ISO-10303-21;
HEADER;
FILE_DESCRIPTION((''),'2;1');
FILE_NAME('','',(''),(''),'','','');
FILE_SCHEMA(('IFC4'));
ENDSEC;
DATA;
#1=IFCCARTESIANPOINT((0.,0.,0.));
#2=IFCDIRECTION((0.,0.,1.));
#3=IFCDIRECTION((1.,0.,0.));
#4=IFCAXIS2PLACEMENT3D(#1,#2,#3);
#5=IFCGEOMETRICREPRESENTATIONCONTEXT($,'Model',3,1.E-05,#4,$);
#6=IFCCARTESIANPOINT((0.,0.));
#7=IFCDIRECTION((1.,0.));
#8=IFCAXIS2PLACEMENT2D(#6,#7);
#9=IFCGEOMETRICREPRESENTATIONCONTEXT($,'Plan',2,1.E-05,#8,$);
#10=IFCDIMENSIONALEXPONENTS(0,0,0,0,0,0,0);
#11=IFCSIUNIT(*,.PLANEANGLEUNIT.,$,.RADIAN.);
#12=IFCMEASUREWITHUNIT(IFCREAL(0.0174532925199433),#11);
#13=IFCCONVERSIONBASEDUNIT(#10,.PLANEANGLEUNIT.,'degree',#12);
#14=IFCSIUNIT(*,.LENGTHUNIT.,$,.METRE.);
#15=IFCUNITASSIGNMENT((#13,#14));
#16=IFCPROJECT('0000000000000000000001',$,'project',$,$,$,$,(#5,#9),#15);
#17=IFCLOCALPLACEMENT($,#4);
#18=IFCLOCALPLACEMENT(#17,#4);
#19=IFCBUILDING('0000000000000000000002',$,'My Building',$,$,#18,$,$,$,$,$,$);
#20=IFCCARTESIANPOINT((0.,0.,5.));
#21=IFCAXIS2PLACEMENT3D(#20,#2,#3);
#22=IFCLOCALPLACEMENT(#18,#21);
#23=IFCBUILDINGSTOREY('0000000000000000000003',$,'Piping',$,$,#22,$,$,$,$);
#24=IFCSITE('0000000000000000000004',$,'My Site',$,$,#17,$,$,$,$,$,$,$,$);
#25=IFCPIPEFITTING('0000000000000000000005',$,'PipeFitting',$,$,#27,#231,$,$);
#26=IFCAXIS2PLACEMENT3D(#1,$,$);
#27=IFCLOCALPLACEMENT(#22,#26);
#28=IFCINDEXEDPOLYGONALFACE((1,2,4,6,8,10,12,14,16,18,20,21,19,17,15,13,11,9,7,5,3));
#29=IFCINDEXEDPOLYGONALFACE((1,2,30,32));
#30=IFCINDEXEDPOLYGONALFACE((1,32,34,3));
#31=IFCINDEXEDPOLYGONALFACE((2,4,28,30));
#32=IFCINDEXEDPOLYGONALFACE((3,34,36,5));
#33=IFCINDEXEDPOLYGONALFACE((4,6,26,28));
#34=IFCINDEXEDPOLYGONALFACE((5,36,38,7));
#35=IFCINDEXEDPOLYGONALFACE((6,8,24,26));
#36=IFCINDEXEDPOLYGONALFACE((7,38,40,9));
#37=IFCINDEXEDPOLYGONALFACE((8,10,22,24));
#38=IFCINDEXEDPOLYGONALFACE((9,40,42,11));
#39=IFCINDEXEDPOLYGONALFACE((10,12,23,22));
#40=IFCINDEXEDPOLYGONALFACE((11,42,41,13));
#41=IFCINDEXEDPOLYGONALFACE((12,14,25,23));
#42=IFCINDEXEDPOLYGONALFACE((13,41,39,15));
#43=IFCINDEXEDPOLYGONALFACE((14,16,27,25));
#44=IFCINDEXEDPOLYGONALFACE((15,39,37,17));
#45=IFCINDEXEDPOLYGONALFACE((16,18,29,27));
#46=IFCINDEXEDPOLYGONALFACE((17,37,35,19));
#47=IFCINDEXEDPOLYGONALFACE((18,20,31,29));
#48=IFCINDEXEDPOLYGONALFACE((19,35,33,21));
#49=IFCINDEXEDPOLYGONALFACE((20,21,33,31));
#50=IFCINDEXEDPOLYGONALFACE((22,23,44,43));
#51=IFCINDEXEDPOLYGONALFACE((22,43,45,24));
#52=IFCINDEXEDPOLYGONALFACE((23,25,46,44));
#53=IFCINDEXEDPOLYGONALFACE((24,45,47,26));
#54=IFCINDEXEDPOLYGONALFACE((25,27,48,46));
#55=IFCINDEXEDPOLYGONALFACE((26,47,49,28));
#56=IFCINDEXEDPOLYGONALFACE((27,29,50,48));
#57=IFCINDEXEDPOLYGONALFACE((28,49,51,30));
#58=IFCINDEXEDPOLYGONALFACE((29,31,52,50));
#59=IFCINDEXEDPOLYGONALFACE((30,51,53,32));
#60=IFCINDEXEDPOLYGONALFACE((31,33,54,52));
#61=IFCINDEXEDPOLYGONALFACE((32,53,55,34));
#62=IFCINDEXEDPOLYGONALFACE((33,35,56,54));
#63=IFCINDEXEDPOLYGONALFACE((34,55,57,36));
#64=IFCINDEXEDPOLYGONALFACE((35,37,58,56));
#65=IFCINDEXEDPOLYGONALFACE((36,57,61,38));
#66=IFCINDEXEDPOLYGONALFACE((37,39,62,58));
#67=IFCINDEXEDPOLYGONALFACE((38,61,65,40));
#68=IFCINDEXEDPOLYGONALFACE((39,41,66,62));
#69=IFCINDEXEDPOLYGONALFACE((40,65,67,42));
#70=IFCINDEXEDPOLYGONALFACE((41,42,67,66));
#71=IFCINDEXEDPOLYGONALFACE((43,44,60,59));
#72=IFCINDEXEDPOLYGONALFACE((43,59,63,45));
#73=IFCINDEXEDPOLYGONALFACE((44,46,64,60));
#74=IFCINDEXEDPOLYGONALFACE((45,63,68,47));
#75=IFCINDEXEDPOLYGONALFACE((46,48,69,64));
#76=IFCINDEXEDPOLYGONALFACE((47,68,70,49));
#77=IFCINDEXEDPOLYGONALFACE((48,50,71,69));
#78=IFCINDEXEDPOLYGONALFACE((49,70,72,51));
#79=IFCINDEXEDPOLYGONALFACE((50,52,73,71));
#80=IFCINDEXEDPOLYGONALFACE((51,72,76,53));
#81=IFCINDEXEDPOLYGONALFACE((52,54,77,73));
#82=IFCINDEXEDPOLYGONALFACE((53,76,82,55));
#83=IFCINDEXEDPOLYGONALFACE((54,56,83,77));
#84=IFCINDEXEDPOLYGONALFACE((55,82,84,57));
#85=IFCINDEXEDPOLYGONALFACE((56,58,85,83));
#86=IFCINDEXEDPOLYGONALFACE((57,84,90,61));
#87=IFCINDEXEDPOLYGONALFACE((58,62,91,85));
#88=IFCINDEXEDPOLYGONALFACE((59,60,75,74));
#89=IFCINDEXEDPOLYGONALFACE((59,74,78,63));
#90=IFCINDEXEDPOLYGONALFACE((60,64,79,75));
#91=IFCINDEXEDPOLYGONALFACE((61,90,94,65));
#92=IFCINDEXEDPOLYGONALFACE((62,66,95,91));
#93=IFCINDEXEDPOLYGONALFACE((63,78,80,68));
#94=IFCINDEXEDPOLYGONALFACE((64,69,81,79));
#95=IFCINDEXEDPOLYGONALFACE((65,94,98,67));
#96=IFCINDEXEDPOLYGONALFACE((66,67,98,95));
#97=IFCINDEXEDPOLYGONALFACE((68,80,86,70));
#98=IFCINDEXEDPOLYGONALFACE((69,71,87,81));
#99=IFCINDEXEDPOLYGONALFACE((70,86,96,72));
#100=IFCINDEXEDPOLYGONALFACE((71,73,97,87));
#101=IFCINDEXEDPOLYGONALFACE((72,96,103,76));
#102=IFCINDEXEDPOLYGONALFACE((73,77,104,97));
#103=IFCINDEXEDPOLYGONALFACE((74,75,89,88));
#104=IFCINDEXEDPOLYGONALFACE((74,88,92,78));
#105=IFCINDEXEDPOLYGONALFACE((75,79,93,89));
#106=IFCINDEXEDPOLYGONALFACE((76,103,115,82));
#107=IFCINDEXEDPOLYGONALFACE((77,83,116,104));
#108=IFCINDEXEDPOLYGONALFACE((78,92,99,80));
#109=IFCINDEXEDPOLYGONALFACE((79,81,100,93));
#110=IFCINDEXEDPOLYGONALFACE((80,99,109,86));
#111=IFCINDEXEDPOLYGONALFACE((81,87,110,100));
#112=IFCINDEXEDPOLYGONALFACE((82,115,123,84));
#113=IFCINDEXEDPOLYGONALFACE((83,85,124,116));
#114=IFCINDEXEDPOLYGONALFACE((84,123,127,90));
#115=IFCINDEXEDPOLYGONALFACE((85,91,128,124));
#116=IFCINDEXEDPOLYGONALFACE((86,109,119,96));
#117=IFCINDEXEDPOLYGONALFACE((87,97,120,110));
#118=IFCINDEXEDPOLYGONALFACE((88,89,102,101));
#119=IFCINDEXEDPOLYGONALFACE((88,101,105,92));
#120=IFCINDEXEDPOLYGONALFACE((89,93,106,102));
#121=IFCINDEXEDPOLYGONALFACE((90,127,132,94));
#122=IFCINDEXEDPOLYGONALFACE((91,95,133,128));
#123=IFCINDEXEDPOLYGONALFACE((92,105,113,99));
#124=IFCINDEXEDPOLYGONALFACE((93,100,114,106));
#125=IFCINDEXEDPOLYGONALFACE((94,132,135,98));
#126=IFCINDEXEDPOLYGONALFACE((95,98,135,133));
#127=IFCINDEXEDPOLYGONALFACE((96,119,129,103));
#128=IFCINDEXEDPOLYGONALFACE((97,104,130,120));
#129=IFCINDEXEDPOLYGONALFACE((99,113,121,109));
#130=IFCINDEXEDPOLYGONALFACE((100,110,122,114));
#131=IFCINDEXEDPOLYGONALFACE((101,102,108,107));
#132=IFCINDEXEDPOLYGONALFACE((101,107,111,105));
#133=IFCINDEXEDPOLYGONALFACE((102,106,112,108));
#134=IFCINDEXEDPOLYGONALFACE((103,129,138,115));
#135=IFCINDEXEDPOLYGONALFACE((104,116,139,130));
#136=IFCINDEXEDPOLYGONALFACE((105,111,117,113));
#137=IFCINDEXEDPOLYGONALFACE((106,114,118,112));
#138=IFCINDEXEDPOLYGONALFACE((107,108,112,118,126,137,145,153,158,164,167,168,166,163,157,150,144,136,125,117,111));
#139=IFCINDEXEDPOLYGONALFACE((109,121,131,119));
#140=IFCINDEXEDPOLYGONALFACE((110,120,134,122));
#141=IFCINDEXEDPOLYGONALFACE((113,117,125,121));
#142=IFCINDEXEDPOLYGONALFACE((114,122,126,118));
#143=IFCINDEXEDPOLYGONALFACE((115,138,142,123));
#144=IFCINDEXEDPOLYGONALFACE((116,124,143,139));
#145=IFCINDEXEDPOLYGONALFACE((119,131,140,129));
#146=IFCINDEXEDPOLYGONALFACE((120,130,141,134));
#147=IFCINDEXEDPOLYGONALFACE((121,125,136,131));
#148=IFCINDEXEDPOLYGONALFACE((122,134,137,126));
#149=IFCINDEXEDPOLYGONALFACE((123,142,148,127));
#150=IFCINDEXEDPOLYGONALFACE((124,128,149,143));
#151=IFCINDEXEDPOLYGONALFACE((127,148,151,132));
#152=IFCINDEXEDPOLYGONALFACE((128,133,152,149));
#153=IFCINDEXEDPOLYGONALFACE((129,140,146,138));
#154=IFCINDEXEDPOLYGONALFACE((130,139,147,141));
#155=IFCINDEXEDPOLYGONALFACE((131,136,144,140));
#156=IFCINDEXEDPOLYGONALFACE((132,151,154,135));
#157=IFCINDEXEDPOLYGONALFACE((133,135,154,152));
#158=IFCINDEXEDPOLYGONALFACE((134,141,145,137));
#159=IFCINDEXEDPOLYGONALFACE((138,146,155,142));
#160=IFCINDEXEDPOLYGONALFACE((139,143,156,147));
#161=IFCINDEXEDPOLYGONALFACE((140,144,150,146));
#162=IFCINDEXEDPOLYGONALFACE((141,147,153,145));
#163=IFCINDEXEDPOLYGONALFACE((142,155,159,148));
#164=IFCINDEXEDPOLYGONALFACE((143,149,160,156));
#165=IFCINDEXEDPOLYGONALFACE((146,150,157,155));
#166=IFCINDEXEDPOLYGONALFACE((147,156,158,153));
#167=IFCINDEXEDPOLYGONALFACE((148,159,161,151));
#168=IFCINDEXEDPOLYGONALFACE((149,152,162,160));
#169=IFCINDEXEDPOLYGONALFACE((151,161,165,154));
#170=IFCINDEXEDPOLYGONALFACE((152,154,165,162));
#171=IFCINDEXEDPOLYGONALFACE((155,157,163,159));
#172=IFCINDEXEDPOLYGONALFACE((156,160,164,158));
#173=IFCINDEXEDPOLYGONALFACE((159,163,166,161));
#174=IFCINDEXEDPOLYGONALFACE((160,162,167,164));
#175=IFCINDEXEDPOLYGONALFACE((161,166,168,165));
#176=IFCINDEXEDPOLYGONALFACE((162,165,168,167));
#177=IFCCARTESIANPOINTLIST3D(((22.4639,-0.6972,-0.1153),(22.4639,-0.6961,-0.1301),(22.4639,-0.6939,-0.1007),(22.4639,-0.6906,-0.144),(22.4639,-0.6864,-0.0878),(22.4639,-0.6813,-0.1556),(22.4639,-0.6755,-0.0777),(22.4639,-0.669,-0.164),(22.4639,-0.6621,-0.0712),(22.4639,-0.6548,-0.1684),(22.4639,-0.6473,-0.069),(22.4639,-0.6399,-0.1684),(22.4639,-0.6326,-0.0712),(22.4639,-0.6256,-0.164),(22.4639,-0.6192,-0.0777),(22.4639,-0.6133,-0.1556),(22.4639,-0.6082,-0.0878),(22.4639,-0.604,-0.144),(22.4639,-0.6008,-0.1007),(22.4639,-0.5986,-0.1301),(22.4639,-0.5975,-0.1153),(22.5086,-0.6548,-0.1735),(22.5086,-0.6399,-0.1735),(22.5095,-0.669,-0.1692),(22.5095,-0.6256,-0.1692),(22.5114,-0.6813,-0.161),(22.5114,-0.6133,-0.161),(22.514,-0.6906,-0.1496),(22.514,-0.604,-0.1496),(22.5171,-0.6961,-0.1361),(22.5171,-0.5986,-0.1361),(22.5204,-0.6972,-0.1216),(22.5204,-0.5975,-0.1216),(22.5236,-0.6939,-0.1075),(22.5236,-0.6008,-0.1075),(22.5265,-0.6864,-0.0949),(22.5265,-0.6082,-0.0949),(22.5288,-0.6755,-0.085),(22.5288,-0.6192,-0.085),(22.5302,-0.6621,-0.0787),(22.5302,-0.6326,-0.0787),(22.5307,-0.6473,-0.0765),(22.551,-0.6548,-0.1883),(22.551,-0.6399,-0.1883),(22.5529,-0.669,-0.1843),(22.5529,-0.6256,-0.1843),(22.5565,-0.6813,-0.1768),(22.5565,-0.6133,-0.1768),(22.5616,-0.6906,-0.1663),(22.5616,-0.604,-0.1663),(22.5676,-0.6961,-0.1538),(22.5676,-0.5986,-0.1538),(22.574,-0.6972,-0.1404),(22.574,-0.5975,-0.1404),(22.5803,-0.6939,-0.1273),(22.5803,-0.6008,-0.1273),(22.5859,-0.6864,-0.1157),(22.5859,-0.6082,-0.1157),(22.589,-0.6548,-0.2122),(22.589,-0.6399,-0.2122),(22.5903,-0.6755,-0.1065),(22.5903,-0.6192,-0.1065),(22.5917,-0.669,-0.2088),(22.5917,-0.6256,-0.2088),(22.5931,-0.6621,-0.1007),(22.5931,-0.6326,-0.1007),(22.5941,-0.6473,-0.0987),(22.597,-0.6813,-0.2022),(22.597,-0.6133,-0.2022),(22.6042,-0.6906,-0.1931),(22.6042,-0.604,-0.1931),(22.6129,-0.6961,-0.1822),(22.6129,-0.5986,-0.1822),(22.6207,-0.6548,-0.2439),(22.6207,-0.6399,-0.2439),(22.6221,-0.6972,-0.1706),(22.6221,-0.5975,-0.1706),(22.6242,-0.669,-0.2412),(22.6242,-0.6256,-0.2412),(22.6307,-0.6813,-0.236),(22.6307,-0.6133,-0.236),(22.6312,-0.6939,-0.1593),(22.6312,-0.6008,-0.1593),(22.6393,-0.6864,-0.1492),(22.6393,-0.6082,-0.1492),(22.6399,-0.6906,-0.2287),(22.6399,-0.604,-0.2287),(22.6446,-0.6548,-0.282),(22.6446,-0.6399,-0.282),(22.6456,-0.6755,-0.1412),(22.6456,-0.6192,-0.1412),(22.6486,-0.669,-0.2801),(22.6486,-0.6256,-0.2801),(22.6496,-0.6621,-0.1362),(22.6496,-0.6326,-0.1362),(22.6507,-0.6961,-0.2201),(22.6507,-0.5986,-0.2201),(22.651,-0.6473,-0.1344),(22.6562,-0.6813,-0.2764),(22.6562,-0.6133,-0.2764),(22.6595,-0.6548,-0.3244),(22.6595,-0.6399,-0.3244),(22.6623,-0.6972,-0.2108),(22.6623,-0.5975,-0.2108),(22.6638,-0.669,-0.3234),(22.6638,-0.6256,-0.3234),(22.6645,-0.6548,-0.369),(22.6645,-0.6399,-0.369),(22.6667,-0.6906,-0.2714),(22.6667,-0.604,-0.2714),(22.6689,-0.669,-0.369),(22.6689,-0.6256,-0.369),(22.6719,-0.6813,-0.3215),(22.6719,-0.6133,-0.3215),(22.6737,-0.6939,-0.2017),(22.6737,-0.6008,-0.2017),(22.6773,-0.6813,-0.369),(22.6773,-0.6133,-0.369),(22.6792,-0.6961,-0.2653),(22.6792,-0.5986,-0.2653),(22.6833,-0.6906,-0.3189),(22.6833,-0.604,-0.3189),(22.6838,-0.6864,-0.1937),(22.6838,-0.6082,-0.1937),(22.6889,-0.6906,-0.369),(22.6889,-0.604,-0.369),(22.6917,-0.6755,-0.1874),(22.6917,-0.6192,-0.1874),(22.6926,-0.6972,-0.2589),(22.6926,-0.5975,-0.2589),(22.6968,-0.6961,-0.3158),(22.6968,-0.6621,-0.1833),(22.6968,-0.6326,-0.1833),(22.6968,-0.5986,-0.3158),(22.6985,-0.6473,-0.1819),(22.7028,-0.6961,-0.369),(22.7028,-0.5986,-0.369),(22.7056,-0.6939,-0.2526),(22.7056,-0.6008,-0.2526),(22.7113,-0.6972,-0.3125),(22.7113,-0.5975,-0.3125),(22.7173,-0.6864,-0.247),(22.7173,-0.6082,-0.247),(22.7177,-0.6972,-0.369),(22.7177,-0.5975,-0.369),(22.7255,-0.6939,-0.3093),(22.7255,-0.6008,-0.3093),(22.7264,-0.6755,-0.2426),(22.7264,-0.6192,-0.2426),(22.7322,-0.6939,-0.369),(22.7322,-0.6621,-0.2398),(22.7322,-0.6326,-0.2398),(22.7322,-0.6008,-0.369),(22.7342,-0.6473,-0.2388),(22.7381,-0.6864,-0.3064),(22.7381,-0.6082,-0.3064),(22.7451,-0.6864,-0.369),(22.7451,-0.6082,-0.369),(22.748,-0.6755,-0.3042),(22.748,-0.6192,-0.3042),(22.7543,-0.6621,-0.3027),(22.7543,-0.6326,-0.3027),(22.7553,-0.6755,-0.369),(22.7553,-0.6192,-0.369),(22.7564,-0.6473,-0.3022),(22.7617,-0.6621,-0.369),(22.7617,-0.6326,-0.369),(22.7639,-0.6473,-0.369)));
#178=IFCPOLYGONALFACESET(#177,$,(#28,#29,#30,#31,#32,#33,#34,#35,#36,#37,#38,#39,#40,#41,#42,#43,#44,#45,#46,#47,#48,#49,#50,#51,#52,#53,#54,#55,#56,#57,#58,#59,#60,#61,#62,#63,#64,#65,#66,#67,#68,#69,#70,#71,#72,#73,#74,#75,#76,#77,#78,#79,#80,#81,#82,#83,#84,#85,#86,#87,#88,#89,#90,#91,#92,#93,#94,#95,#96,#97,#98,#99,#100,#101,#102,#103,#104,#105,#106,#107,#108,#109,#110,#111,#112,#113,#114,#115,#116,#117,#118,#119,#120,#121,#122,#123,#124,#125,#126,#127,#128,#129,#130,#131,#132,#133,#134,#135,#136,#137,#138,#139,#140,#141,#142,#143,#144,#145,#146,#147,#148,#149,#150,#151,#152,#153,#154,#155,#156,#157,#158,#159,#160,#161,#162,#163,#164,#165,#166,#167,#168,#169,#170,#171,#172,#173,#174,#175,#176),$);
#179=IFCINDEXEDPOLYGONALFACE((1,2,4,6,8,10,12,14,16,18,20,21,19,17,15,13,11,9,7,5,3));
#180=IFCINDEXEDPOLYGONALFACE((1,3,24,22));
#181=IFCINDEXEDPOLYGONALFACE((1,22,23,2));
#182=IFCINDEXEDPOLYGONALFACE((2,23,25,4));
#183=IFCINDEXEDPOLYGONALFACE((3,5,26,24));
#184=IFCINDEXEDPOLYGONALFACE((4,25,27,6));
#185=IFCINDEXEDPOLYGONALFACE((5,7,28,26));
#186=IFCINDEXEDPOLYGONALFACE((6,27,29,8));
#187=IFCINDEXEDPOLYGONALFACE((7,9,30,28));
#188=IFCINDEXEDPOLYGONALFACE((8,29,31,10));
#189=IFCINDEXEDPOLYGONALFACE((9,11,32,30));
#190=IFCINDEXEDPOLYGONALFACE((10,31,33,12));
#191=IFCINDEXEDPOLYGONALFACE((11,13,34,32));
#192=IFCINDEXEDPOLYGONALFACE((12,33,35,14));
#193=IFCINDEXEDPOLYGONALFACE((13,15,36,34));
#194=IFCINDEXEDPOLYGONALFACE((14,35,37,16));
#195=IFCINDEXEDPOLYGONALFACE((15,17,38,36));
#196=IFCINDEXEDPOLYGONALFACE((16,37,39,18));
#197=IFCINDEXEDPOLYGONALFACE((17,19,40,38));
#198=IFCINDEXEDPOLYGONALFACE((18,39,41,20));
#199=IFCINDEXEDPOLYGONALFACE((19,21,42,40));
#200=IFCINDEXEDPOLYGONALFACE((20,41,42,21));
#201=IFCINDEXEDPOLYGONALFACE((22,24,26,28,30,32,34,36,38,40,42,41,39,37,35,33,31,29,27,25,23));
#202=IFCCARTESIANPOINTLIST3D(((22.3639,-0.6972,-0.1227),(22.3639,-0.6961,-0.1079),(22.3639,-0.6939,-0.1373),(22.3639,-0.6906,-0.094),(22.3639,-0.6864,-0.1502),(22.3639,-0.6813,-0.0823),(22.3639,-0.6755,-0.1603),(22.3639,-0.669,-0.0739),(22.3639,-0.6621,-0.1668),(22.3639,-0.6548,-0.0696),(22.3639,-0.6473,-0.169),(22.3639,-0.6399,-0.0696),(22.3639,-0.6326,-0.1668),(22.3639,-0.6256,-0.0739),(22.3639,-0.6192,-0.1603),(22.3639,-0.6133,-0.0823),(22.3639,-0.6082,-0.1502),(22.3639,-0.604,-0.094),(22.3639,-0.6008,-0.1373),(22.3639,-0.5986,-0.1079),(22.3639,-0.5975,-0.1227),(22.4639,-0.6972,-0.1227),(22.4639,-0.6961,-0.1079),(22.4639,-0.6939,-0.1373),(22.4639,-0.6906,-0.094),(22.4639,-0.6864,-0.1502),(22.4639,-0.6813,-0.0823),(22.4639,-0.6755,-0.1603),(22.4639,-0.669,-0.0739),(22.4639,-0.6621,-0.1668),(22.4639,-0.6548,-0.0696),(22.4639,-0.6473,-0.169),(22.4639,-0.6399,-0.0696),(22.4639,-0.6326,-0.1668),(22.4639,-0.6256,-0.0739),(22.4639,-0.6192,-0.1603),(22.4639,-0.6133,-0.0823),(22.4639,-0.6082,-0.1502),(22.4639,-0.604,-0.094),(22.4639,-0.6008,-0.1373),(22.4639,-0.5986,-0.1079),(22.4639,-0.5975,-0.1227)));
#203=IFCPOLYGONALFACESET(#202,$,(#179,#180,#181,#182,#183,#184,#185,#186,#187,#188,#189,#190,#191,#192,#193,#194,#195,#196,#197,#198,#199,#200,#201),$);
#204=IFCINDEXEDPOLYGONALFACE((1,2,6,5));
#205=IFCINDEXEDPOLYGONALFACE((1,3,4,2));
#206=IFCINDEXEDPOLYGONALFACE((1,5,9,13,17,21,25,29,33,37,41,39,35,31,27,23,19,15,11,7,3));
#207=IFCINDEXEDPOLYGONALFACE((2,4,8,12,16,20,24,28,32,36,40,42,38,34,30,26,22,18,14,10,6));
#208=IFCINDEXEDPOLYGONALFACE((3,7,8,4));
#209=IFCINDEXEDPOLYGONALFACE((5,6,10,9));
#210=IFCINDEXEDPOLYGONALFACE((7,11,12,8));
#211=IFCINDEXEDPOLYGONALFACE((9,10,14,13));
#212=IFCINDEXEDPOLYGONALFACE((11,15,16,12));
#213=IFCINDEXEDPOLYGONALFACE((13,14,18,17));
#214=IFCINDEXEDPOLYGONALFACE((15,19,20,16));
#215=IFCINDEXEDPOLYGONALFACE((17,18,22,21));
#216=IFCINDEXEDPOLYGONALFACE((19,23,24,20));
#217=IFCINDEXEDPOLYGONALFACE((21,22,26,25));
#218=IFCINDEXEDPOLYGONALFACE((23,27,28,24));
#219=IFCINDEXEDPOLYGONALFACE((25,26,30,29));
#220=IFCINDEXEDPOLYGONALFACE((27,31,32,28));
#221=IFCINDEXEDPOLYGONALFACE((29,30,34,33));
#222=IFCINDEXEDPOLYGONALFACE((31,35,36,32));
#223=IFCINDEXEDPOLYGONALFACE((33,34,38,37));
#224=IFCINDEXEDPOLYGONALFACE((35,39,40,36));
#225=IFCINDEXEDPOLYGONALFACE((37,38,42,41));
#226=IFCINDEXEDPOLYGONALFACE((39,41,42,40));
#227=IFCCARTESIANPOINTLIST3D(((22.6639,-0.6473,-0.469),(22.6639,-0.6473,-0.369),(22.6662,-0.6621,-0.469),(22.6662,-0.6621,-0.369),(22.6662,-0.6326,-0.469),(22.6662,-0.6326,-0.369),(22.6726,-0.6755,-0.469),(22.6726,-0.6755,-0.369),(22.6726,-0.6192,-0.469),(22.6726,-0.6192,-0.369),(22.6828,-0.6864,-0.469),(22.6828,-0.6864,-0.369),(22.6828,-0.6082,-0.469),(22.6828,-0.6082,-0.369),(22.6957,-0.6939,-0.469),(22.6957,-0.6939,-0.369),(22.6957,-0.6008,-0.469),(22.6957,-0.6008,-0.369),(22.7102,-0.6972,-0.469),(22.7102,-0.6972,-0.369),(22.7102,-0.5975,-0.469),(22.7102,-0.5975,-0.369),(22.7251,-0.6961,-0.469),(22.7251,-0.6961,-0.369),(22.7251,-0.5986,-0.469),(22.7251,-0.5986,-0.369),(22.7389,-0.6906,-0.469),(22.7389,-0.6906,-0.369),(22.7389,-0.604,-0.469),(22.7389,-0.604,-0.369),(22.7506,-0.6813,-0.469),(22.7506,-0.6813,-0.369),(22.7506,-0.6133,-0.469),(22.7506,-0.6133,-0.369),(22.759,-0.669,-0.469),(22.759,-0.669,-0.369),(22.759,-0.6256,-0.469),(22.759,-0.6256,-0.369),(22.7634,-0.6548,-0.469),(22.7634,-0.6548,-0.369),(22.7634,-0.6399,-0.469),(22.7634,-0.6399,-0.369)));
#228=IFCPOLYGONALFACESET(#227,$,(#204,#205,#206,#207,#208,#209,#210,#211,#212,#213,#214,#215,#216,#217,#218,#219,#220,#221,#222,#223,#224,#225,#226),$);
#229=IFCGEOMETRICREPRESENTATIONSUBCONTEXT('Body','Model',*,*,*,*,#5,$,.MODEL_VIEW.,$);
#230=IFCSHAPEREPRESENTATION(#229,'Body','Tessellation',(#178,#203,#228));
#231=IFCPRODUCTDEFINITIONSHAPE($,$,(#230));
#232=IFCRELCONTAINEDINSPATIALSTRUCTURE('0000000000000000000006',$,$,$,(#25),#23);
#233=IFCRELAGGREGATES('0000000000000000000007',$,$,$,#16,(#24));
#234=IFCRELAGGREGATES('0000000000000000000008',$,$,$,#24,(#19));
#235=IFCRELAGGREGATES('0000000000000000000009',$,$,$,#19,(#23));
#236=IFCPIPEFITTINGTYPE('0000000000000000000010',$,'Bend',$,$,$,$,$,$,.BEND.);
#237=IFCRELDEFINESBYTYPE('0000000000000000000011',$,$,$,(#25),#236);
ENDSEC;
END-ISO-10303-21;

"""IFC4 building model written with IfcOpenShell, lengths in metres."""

from ifc_helpers import new_model, entity, si_unit, converted_unit, frame, origin_with_axes, origin_2d_with_axis, place, context, subcontext, project, spatial, circle, extrude, source, transform, mapped, type_object, type_shapes, element, save


model = new_model("IFC4")

# Units and contexts
model_context = context("Model", 3, precision=1e-05, world=origin_with_axes())
plan_context = context("Plan", 2, precision=1e-05, world=origin_2d_with_axis())
body_context = subcontext(model_context, "Body", "Model", "MODEL_VIEW")
ifc_project = project(units=[converted_unit("PLANEANGLEUNIT", "degree", entity("IfcReal", 0.0174532925199433), si_unit("PLANEANGLEUNIT", "RADIAN"), dimensions=[0, 0, 0, 0, 0, 0, 0]), si_unit("LENGTHUNIT", "METRE")], contexts=[model_context, plan_context])

# Site, building, storey
site_placement = place(None, origin_with_axes())
site = spatial("IfcSite", under=ifc_project, at=site_placement, Name="My Site")
building_placement = place(site_placement, origin_with_axes())
building = spatial("IfcBuilding", under=site, at=building_placement, Name="My Building")
storey_placement = place(building_placement, frame((0.0, 0.0, 5.0), z_axis=(0.0, 0.0, 1.0), x_axis=(1.0, 0.0, 0.0)))
storey = spatial("IfcBuildingStorey", under=building, at=storey_placement, Name="Piping")

# Pipe fitting
pipe_fitting_type_1 = type_object("IfcPipeFittingType", Name="Bend", PredefinedType="BEND")
shared_shape = source(origin_with_axes(), body_context, "Body", "SolidModel", [
    entity("IfcSweptDiskSolid", entity("IfcIndexedPolyCurve", entity("IfcCartesianPointList3D", [[0.0, 0.0, -0.1], [0.0732, 0.0, -0.2768], [0.25, 0.0, -0.35]]), [entity("IfcArcIndex", [1, 2, 3])]), 0.05),
    extrude(circle(Radius=0.05), origin_with_axes(), (0.0, 0.0, -1.0), 0.1),
    extrude(circle(Radius=0.05), frame((0.25, 0.0, -0.35), z_axis=(1.0, 0.0, 0.0), x_axis=(0.0, 0.0, 1.0)), (0.0, 0.0, 1.0), 0.1),
])
type_shapes(pipe_fitting_type_1, [shared_shape])
for number, where, z_axis, x_axis, name in (
    (1, (22.3639, -0.6473, -0.119), (-1.0, -0.000001, 0.0), (0.0, 0.0, -1.0), "PipeFitting"),
):
    element("IfcPipeFitting", number, at=place(storey_placement, frame(where, z_axis=z_axis, x_axis=x_axis)), inside=storey, type_object=pipe_fitting_type_1, Name=name, context=body_context, shape_type="MappedRepresentation", body=[
        mapped(shared_shape, transform((0.0, 0.0, 0.0), x_axis=(1.0, 0.0, 0.0), y_axis=(0.0, 1.0, 0.0), z_axis=(0.0, 0.0, 1.0), scale=1.0)),
    ])

save(model, "model.ifc")
